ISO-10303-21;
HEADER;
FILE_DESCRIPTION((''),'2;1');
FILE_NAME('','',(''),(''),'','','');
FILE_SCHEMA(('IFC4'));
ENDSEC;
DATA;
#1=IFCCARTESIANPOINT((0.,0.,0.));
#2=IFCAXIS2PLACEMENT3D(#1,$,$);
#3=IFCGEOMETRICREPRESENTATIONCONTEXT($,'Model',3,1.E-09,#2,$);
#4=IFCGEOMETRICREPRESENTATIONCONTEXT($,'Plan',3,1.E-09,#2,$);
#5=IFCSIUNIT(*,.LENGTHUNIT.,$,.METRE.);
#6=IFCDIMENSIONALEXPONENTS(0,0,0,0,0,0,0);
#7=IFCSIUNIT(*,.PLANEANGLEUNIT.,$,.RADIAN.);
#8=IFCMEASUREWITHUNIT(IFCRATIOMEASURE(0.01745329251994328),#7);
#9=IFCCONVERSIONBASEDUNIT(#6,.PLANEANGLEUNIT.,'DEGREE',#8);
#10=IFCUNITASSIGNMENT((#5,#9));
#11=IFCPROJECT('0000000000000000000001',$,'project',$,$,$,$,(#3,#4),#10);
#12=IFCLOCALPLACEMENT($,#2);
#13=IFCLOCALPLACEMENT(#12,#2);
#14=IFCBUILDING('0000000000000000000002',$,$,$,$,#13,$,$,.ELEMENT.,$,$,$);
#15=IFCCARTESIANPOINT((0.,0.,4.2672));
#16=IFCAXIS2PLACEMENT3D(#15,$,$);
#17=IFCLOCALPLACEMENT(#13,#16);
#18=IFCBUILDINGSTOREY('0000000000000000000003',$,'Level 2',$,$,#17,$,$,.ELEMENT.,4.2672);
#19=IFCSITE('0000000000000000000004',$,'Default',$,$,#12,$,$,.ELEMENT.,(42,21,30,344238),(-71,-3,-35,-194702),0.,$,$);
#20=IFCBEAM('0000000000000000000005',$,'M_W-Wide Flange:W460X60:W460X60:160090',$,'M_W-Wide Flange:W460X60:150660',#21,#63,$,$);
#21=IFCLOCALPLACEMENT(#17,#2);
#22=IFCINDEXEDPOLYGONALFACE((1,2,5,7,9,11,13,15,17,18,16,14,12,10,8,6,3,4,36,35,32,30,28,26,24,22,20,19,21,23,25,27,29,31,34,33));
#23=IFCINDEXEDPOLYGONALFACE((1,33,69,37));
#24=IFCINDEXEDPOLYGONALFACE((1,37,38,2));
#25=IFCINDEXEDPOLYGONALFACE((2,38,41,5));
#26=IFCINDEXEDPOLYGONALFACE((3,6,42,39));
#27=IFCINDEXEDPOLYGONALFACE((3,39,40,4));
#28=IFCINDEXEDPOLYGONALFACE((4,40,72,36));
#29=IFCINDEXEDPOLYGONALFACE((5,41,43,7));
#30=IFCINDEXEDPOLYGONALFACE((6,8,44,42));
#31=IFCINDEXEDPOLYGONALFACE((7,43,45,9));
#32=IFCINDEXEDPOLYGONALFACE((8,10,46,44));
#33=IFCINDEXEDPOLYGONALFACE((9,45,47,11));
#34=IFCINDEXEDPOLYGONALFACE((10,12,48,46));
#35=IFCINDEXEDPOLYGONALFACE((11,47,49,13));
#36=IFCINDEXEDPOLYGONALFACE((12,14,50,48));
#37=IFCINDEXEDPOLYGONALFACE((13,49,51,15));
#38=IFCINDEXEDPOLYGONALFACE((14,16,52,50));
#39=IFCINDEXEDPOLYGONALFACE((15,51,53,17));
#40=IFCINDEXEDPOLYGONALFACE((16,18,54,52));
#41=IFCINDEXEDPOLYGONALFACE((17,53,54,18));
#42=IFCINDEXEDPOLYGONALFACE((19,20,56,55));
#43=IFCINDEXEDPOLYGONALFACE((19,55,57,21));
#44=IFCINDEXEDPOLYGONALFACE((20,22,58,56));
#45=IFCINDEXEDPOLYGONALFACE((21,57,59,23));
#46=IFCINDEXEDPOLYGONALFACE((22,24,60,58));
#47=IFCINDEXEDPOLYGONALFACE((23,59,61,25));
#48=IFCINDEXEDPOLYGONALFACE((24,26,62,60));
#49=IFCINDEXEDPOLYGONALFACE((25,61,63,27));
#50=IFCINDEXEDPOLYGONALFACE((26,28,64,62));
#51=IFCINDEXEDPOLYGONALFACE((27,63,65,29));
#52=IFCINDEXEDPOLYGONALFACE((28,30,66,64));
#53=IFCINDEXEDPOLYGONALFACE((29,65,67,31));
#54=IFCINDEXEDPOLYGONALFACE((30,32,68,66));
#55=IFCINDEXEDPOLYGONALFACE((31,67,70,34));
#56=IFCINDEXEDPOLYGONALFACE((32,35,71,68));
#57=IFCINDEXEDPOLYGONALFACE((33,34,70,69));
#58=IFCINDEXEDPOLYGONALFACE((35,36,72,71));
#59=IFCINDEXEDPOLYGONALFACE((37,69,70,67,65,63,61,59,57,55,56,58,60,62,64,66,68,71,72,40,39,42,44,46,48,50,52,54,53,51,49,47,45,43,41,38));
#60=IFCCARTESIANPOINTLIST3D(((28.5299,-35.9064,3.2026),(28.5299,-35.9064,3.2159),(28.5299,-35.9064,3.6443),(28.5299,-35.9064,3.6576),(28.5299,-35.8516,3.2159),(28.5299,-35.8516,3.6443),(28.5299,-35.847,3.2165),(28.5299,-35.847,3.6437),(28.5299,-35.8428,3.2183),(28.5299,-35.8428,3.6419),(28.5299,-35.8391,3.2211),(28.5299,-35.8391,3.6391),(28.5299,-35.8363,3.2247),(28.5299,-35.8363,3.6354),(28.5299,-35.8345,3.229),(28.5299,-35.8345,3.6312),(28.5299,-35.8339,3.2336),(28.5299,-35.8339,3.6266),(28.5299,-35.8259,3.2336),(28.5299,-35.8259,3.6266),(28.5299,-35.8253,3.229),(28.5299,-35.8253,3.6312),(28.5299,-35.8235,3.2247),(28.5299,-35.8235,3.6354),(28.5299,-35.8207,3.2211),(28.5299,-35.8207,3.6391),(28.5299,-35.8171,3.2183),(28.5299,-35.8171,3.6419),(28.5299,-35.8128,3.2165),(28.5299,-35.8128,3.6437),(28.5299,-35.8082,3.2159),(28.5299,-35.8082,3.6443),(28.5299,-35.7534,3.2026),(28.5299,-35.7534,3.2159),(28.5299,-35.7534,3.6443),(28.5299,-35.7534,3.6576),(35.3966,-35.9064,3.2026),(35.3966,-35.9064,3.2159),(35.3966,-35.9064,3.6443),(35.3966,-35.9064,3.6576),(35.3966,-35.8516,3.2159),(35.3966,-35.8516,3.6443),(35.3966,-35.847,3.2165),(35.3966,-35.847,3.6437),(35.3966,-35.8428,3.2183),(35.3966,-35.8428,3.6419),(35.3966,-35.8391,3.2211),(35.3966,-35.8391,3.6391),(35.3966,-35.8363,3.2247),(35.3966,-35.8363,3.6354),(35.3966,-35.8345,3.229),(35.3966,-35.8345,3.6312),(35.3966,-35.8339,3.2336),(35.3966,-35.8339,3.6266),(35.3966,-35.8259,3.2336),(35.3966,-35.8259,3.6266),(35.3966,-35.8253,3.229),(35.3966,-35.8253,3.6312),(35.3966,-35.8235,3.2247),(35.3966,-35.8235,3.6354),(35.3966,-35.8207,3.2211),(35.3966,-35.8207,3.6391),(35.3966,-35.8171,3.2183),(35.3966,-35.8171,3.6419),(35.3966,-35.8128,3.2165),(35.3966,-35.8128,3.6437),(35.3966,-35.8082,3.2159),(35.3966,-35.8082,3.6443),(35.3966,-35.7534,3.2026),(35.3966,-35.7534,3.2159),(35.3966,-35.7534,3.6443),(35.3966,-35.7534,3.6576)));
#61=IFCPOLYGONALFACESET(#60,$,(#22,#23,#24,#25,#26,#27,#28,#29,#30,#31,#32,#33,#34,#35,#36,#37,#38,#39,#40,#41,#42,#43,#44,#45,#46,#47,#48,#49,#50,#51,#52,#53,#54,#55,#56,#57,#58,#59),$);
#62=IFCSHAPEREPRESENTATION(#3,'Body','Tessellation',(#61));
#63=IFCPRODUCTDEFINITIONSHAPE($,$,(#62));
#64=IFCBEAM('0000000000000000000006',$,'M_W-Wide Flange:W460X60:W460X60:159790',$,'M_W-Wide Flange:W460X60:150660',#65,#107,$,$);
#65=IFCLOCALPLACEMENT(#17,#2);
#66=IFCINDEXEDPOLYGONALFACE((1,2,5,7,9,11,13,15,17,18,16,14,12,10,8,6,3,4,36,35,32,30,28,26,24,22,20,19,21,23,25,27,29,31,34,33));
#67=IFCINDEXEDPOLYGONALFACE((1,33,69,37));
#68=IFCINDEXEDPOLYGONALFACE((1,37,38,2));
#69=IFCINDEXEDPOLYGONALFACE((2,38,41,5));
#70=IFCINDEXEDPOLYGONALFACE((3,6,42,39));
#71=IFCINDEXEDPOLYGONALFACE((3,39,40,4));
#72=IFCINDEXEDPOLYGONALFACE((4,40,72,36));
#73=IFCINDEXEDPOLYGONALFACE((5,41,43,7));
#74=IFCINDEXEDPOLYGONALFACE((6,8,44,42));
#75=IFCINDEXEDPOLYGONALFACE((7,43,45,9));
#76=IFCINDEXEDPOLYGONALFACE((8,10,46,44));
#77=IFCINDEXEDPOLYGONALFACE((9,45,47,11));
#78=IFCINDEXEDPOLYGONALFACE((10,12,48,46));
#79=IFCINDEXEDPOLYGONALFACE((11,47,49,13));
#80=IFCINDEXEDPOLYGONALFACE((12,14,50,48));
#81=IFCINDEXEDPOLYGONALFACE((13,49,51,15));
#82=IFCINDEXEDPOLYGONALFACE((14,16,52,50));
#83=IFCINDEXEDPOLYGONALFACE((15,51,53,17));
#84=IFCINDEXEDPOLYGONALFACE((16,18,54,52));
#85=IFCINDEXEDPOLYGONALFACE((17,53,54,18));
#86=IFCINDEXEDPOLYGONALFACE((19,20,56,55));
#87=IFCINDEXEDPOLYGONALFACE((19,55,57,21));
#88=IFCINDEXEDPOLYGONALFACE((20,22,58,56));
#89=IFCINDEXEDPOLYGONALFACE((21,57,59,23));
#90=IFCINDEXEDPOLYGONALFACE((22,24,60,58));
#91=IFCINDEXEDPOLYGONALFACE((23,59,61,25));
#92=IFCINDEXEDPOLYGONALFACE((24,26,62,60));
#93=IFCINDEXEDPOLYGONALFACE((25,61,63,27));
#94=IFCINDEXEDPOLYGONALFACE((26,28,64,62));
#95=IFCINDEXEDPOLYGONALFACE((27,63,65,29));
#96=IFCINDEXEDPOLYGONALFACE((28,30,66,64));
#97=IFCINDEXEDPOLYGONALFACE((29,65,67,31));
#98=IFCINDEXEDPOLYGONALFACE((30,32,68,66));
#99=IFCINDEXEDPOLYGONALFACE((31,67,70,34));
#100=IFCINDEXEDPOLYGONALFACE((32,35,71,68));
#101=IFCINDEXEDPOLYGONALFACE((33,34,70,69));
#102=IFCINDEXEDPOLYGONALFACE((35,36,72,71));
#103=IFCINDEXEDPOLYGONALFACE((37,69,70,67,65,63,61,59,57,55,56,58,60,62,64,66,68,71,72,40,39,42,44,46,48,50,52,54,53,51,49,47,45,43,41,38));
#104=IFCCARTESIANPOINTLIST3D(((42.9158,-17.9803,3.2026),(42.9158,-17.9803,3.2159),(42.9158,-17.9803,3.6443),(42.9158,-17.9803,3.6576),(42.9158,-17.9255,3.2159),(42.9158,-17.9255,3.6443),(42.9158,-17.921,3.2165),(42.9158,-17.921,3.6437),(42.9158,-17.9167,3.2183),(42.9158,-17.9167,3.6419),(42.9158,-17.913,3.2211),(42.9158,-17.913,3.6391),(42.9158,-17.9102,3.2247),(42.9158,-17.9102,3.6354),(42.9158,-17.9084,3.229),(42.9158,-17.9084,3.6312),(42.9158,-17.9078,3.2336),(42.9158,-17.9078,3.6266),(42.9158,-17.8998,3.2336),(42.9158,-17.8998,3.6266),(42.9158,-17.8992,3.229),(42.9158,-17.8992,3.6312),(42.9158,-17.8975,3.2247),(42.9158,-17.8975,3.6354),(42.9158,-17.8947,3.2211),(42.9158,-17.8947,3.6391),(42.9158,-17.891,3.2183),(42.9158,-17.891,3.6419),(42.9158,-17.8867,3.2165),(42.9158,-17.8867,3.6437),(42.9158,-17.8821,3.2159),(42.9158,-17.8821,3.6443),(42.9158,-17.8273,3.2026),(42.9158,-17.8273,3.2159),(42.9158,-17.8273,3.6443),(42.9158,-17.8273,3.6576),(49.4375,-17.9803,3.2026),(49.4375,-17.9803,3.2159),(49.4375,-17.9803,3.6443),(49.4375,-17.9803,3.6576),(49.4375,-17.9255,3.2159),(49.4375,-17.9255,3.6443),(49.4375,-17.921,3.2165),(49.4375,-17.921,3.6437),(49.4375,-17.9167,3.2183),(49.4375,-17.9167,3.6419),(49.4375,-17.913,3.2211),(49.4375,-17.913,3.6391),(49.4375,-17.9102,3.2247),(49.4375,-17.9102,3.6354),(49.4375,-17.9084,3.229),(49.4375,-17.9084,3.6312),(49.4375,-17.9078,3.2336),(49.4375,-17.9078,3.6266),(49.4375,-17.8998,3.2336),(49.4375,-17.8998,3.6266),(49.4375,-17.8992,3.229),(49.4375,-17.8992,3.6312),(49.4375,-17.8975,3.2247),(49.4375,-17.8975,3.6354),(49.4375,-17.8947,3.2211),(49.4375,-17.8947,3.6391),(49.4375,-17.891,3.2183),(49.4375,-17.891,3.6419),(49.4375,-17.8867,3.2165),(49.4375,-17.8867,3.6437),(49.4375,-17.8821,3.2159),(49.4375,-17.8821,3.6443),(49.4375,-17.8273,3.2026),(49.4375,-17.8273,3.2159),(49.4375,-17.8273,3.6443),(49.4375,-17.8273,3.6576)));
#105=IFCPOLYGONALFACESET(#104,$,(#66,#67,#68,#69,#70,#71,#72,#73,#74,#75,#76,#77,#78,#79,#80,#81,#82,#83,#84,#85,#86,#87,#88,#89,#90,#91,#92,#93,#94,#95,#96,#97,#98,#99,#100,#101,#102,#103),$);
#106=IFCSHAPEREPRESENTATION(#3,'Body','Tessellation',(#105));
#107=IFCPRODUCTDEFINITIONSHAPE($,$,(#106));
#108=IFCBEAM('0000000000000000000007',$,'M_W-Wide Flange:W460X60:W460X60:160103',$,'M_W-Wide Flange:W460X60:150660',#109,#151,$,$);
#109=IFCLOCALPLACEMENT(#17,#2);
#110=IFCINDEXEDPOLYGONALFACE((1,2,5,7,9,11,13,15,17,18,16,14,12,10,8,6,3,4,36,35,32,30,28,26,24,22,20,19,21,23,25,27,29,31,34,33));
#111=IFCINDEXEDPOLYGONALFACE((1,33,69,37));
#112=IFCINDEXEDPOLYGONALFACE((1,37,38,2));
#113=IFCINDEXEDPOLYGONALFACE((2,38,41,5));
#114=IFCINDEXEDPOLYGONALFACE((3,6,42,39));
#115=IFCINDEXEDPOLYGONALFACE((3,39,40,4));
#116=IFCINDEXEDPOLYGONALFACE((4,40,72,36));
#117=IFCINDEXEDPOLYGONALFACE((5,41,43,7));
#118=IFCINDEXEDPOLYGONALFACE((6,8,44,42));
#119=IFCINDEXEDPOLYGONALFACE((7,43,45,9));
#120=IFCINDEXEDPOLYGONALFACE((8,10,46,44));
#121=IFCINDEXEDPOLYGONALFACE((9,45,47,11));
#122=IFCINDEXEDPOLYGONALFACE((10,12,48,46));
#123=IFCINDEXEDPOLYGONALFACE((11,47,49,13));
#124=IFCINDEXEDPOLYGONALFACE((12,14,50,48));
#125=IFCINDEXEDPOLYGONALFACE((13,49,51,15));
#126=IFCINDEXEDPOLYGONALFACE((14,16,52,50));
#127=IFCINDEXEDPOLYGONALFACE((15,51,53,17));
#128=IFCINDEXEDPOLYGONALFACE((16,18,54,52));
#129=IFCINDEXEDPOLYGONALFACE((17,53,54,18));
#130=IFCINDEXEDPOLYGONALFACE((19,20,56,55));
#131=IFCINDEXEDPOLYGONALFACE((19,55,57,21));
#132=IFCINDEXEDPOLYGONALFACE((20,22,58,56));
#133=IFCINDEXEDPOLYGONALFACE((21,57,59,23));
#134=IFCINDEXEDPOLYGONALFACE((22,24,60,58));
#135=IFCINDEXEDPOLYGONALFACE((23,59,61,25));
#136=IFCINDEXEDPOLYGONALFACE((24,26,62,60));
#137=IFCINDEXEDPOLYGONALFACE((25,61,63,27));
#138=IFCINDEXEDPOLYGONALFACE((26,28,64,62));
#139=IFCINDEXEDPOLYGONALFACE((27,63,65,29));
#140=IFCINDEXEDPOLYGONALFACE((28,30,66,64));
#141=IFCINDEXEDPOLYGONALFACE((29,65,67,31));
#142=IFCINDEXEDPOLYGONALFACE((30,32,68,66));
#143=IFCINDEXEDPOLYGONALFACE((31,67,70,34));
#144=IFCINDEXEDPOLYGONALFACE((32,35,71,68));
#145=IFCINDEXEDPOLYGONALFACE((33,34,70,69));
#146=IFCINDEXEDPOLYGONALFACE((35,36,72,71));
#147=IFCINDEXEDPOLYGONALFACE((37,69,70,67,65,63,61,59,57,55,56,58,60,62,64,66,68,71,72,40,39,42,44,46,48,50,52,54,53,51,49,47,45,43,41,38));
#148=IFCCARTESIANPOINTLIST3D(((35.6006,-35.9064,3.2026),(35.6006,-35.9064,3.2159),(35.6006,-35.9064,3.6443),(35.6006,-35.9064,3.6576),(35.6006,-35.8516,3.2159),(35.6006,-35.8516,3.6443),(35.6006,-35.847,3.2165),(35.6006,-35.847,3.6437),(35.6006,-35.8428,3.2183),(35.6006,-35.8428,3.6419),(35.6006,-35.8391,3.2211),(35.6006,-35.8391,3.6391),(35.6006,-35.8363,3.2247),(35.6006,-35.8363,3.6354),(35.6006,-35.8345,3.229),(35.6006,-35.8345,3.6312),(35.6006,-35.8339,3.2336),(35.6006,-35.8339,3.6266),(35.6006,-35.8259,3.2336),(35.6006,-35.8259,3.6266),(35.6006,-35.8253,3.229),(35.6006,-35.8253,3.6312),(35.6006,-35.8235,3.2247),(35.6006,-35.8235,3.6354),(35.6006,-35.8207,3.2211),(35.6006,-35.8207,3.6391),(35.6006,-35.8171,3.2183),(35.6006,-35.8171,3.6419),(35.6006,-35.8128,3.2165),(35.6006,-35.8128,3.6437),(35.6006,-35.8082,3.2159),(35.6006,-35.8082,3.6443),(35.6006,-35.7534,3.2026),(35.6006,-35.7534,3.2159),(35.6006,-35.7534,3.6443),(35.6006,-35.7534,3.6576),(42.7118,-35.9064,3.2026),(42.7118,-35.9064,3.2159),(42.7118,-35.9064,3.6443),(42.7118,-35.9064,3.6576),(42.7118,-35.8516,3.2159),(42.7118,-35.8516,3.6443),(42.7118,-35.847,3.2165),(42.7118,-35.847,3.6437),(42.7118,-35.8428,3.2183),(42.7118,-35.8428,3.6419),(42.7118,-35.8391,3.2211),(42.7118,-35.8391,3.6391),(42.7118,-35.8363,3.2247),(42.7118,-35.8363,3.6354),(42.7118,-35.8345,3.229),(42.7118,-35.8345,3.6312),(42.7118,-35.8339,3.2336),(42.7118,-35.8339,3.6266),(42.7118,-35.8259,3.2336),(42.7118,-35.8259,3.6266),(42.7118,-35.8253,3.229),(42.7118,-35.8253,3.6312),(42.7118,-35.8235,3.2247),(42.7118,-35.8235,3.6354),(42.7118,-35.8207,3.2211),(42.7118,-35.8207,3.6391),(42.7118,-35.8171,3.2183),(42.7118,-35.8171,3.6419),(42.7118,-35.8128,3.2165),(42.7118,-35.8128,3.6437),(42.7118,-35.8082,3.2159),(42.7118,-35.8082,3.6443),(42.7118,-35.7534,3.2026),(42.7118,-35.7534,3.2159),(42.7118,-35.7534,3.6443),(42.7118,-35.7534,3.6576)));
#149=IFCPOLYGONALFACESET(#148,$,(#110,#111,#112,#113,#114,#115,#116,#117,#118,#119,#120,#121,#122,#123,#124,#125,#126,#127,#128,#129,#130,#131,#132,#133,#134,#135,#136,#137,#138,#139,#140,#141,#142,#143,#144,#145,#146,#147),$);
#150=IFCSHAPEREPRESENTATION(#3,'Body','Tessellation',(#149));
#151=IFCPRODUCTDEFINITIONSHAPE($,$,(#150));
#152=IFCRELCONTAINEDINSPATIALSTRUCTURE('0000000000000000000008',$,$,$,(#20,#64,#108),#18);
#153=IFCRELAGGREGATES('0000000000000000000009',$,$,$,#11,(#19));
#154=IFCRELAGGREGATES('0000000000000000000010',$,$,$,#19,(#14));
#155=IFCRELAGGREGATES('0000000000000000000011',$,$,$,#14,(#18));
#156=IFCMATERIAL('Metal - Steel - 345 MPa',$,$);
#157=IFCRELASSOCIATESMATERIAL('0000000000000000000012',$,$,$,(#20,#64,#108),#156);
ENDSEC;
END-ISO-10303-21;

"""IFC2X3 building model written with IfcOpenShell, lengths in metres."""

from ifc_helpers import new_model, entity, si_unit, converted_unit, frame, frame_2d, origin, place, context, project, spatial, polyline, circle_curve, parameter, trimmed, segment, composite_curve, outline, extrude, material, element, save


model = new_model("IFC2X3")

# Units and contexts
model_context = context("Model", 3, precision=1e-09, world=origin())
plan_context = context("Plan", 3, precision=1e-09, world=origin())
ifc_project = project(units=[si_unit("LENGTHUNIT", "METRE"), converted_unit("PLANEANGLEUNIT", "DEGREE", entity("IfcRatioMeasure", 0.01745329251994328), si_unit("PLANEANGLEUNIT", "RADIAN"), dimensions=[0, 0, 0, 0, 0, 0, 0])], contexts=[model_context, plan_context])

# Site, building, storey
site_placement = place(None, origin())
site = spatial("IfcSite", under=ifc_project, at=site_placement, Name="Default", CompositionType="ELEMENT", RefLatitude=(42, 21, 30, 344238), RefLongitude=(-71, -3, -35, -194702), RefElevation=0.0)
building_placement = place(site_placement, origin())
building = spatial("IfcBuilding", under=site, at=building_placement, CompositionType="ELEMENT")
storey_placement = place(building_placement, frame((0.0, 0.0, 4.2672)))
storey = spatial("IfcBuildingStorey", under=building, at=storey_placement, Name="Level 2", CompositionType="ELEMENT", Elevation=4.2672)

# Shared definitions
ifc_material = material(Name="Metal - Steel - 345 MPa")

# Beams
beam_1_placement = place(storey_placement, frame((28.4279, -35.8299, 3.6576), z_axis=(0.0, 0.0, 1.0), x_axis=(0.0, -1.0, 0.0)))
element("IfcBeam", 1, at=beam_1_placement, inside=storey, material=ifc_material, Name="M_W-Wide Flange:W460X60:W460X60:160090", ObjectType="M_W-Wide Flange:W460X60:150660", context=model_context, shape_type="SweptSolid", body=[
    extrude(outline(composite_curve([segment(polyline([(-0.0765, -0.2142), (-0.0765, -0.2275)]), True, "CONTINUOUS"), segment(polyline([(-0.0765, -0.2275), (0.0765, -0.2275)]), True, "CONTINUOUS"), segment(polyline([(0.0765, -0.2275), (0.0765, -0.2142)]), True, "CONTINUOUS"), segment(polyline([(0.0765, -0.2142), (0.0217, -0.2142)]), True, "CONTINUOUS"), segment(trimmed(circle_curve(frame_2d((0.0217, -0.1965), x_axis=(0.0, -1.0)), 0.0177), [parameter(270.0)], [parameter(360.0)], True, "PARAMETER"), False, "CONTINUOUS"), segment(polyline([(0.004, -0.1965), (0.004, 0.1965)]), True, "CONTINUOUS"), segment(trimmed(circle_curve(frame_2d((0.0217, 0.1965), x_axis=(-1.0, 0.0)), 0.0177), [parameter(270.0)], [parameter(360.0)], True, "PARAMETER"), False, "CONTINUOUS"), segment(polyline([(0.0217, 0.2142), (0.0765, 0.2142)]), True, "CONTINUOUS"), segment(polyline([(0.0765, 0.2142), (0.0765, 0.2275)]), True, "CONTINUOUS"), segment(polyline([(0.0765, 0.2275), (-0.0765, 0.2275)]), True, "CONTINUOUS"), segment(polyline([(-0.0765, 0.2275), (-0.0765, 0.2142)]), True, "CONTINUOUS"), segment(polyline([(-0.0765, 0.2142), (-0.0217, 0.2142)]), True, "CONTINUOUS"), segment(trimmed(circle_curve(frame_2d((-0.0217, 0.1965), x_axis=(0.0, 1.0)), 0.0177), [parameter(270.0)], [parameter(360.0)], True, "PARAMETER"), False, "CONTINUOUS"), segment(polyline([(-0.004, 0.1965), (-0.004, -0.1965)]), True, "CONTINUOUS"), segment(trimmed(circle_curve(frame_2d((-0.0217, -0.1965), x_axis=(1.0, 0.0)), 0.0177), [parameter(270.0)], [parameter(0.0)], True, "PARAMETER"), False, "CONTINUOUS"), segment(polyline([(-0.0217, -0.2142), (-0.0765, -0.2142)]), True, "CONTINUOUS")], self_intersect=False)), frame((0.0, 0.102, -0.2275), z_axis=(0.0, -1.0, 0.0), x_axis=(1.0, 0.0, 0.0)), (0.0, 0.0, -1.0), 6.8668),
])
beam_2_placement = place(storey_placement, frame((42.8138, -17.9038, 3.6576), z_axis=(0.0, 0.0, 1.0), x_axis=(0.0, -1.0, 0.0)))
element("IfcBeam", 2, at=beam_2_placement, inside=storey, material=ifc_material, Name="M_W-Wide Flange:W460X60:W460X60:159790", ObjectType="M_W-Wide Flange:W460X60:150660", context=model_context, shape_type="SweptSolid", body=[
    extrude(outline(composite_curve([segment(polyline([(-0.0765, -0.2142), (-0.0765, -0.2275)]), True, "CONTINUOUS"), segment(polyline([(-0.0765, -0.2275), (0.0765, -0.2275)]), True, "CONTINUOUS"), segment(polyline([(0.0765, -0.2275), (0.0765, -0.2142)]), True, "CONTINUOUS"), segment(polyline([(0.0765, -0.2142), (0.0217, -0.2142)]), True, "CONTINUOUS"), segment(trimmed(circle_curve(frame_2d((0.0217, -0.1965), x_axis=(0.0, -1.0)), 0.0177), [parameter(270.0)], [parameter(360.0)], True, "PARAMETER"), False, "CONTINUOUS"), segment(polyline([(0.004, -0.1965), (0.004, 0.1965)]), True, "CONTINUOUS"), segment(trimmed(circle_curve(frame_2d((0.0217, 0.1965), x_axis=(-1.0, 0.0)), 0.0177), [parameter(270.0)], [parameter(360.0)], True, "PARAMETER"), False, "CONTINUOUS"), segment(polyline([(0.0217, 0.2142), (0.0765, 0.2142)]), True, "CONTINUOUS"), segment(polyline([(0.0765, 0.2142), (0.0765, 0.2275)]), True, "CONTINUOUS"), segment(polyline([(0.0765, 0.2275), (-0.0765, 0.2275)]), True, "CONTINUOUS"), segment(polyline([(-0.0765, 0.2275), (-0.0765, 0.2142)]), True, "CONTINUOUS"), segment(polyline([(-0.0765, 0.2142), (-0.0217, 0.2142)]), True, "CONTINUOUS"), segment(trimmed(circle_curve(frame_2d((-0.0217, 0.1965), x_axis=(0.0, 1.0)), 0.0177), [parameter(270.0)], [parameter(360.0)], True, "PARAMETER"), False, "CONTINUOUS"), segment(polyline([(-0.004, 0.1965), (-0.004, -0.1965)]), True, "CONTINUOUS"), segment(trimmed(circle_curve(frame_2d((-0.0217, -0.1965), x_axis=(1.0, 0.0)), 0.0177), [parameter(270.0)], [parameter(0.0)], True, "PARAMETER"), False, "CONTINUOUS"), segment(polyline([(-0.0217, -0.2142), (-0.0765, -0.2142)]), True, "CONTINUOUS")], self_intersect=False)), frame((0.0, 0.102, -0.2275), z_axis=(0.0, -1.0, 0.0), x_axis=(1.0, 0.0, 0.0)), (0.0, 0.0, -1.0), 6.5217),
])
beam_3_placement = place(storey_placement, frame((35.4986, -35.8299, 3.6576), z_axis=(0.0, 0.0, 1.0), x_axis=(0.0, -1.0, 0.0)))
element("IfcBeam", 3, at=beam_3_placement, inside=storey, material=ifc_material, Name="M_W-Wide Flange:W460X60:W460X60:160103", ObjectType="M_W-Wide Flange:W460X60:150660", context=model_context, shape_type="SweptSolid", body=[
    extrude(outline(composite_curve([segment(polyline([(-0.0765, -0.2142), (-0.0765, -0.2275)]), True, "CONTINUOUS"), segment(polyline([(-0.0765, -0.2275), (0.0765, -0.2275)]), True, "CONTINUOUS"), segment(polyline([(0.0765, -0.2275), (0.0765, -0.2142)]), True, "CONTINUOUS"), segment(polyline([(0.0765, -0.2142), (0.0217, -0.2142)]), True, "CONTINUOUS"), segment(trimmed(circle_curve(frame_2d((0.0217, -0.1965), x_axis=(0.0, -1.0)), 0.0177), [parameter(270.0)], [parameter(360.0)], True, "PARAMETER"), False, "CONTINUOUS"), segment(polyline([(0.004, -0.1965), (0.004, 0.1965)]), True, "CONTINUOUS"), segment(trimmed(circle_curve(frame_2d((0.0217, 0.1965), x_axis=(-1.0, 0.0)), 0.0177), [parameter(270.0)], [parameter(360.0)], True, "PARAMETER"), False, "CONTINUOUS"), segment(polyline([(0.0217, 0.2142), (0.0765, 0.2142)]), True, "CONTINUOUS"), segment(polyline([(0.0765, 0.2142), (0.0765, 0.2275)]), True, "CONTINUOUS"), segment(polyline([(0.0765, 0.2275), (-0.0765, 0.2275)]), True, "CONTINUOUS"), segment(polyline([(-0.0765, 0.2275), (-0.0765, 0.2142)]), True, "CONTINUOUS"), segment(polyline([(-0.0765, 0.2142), (-0.0217, 0.2142)]), True, "CONTINUOUS"), segment(trimmed(circle_curve(frame_2d((-0.0217, 0.1965), x_axis=(0.0, 1.0)), 0.0177), [parameter(270.0)], [parameter(360.0)], True, "PARAMETER"), False, "CONTINUOUS"), segment(polyline([(-0.004, 0.1965), (-0.004, -0.1965)]), True, "CONTINUOUS"), segment(trimmed(circle_curve(frame_2d((-0.0217, -0.1965), x_axis=(1.0, 0.0)), 0.0177), [parameter(270.0)], [parameter(0.0)], True, "PARAMETER"), False, "CONTINUOUS"), segment(polyline([(-0.0217, -0.2142), (-0.0765, -0.2142)]), True, "CONTINUOUS")], self_intersect=False)), frame((0.0, 0.102, -0.2275), z_axis=(0.0, -1.0, 0.0), x_axis=(1.0, 0.0, 0.0)), (0.0, 0.0, -1.0), 7.1112),
])

save(model, "model.ifc")
